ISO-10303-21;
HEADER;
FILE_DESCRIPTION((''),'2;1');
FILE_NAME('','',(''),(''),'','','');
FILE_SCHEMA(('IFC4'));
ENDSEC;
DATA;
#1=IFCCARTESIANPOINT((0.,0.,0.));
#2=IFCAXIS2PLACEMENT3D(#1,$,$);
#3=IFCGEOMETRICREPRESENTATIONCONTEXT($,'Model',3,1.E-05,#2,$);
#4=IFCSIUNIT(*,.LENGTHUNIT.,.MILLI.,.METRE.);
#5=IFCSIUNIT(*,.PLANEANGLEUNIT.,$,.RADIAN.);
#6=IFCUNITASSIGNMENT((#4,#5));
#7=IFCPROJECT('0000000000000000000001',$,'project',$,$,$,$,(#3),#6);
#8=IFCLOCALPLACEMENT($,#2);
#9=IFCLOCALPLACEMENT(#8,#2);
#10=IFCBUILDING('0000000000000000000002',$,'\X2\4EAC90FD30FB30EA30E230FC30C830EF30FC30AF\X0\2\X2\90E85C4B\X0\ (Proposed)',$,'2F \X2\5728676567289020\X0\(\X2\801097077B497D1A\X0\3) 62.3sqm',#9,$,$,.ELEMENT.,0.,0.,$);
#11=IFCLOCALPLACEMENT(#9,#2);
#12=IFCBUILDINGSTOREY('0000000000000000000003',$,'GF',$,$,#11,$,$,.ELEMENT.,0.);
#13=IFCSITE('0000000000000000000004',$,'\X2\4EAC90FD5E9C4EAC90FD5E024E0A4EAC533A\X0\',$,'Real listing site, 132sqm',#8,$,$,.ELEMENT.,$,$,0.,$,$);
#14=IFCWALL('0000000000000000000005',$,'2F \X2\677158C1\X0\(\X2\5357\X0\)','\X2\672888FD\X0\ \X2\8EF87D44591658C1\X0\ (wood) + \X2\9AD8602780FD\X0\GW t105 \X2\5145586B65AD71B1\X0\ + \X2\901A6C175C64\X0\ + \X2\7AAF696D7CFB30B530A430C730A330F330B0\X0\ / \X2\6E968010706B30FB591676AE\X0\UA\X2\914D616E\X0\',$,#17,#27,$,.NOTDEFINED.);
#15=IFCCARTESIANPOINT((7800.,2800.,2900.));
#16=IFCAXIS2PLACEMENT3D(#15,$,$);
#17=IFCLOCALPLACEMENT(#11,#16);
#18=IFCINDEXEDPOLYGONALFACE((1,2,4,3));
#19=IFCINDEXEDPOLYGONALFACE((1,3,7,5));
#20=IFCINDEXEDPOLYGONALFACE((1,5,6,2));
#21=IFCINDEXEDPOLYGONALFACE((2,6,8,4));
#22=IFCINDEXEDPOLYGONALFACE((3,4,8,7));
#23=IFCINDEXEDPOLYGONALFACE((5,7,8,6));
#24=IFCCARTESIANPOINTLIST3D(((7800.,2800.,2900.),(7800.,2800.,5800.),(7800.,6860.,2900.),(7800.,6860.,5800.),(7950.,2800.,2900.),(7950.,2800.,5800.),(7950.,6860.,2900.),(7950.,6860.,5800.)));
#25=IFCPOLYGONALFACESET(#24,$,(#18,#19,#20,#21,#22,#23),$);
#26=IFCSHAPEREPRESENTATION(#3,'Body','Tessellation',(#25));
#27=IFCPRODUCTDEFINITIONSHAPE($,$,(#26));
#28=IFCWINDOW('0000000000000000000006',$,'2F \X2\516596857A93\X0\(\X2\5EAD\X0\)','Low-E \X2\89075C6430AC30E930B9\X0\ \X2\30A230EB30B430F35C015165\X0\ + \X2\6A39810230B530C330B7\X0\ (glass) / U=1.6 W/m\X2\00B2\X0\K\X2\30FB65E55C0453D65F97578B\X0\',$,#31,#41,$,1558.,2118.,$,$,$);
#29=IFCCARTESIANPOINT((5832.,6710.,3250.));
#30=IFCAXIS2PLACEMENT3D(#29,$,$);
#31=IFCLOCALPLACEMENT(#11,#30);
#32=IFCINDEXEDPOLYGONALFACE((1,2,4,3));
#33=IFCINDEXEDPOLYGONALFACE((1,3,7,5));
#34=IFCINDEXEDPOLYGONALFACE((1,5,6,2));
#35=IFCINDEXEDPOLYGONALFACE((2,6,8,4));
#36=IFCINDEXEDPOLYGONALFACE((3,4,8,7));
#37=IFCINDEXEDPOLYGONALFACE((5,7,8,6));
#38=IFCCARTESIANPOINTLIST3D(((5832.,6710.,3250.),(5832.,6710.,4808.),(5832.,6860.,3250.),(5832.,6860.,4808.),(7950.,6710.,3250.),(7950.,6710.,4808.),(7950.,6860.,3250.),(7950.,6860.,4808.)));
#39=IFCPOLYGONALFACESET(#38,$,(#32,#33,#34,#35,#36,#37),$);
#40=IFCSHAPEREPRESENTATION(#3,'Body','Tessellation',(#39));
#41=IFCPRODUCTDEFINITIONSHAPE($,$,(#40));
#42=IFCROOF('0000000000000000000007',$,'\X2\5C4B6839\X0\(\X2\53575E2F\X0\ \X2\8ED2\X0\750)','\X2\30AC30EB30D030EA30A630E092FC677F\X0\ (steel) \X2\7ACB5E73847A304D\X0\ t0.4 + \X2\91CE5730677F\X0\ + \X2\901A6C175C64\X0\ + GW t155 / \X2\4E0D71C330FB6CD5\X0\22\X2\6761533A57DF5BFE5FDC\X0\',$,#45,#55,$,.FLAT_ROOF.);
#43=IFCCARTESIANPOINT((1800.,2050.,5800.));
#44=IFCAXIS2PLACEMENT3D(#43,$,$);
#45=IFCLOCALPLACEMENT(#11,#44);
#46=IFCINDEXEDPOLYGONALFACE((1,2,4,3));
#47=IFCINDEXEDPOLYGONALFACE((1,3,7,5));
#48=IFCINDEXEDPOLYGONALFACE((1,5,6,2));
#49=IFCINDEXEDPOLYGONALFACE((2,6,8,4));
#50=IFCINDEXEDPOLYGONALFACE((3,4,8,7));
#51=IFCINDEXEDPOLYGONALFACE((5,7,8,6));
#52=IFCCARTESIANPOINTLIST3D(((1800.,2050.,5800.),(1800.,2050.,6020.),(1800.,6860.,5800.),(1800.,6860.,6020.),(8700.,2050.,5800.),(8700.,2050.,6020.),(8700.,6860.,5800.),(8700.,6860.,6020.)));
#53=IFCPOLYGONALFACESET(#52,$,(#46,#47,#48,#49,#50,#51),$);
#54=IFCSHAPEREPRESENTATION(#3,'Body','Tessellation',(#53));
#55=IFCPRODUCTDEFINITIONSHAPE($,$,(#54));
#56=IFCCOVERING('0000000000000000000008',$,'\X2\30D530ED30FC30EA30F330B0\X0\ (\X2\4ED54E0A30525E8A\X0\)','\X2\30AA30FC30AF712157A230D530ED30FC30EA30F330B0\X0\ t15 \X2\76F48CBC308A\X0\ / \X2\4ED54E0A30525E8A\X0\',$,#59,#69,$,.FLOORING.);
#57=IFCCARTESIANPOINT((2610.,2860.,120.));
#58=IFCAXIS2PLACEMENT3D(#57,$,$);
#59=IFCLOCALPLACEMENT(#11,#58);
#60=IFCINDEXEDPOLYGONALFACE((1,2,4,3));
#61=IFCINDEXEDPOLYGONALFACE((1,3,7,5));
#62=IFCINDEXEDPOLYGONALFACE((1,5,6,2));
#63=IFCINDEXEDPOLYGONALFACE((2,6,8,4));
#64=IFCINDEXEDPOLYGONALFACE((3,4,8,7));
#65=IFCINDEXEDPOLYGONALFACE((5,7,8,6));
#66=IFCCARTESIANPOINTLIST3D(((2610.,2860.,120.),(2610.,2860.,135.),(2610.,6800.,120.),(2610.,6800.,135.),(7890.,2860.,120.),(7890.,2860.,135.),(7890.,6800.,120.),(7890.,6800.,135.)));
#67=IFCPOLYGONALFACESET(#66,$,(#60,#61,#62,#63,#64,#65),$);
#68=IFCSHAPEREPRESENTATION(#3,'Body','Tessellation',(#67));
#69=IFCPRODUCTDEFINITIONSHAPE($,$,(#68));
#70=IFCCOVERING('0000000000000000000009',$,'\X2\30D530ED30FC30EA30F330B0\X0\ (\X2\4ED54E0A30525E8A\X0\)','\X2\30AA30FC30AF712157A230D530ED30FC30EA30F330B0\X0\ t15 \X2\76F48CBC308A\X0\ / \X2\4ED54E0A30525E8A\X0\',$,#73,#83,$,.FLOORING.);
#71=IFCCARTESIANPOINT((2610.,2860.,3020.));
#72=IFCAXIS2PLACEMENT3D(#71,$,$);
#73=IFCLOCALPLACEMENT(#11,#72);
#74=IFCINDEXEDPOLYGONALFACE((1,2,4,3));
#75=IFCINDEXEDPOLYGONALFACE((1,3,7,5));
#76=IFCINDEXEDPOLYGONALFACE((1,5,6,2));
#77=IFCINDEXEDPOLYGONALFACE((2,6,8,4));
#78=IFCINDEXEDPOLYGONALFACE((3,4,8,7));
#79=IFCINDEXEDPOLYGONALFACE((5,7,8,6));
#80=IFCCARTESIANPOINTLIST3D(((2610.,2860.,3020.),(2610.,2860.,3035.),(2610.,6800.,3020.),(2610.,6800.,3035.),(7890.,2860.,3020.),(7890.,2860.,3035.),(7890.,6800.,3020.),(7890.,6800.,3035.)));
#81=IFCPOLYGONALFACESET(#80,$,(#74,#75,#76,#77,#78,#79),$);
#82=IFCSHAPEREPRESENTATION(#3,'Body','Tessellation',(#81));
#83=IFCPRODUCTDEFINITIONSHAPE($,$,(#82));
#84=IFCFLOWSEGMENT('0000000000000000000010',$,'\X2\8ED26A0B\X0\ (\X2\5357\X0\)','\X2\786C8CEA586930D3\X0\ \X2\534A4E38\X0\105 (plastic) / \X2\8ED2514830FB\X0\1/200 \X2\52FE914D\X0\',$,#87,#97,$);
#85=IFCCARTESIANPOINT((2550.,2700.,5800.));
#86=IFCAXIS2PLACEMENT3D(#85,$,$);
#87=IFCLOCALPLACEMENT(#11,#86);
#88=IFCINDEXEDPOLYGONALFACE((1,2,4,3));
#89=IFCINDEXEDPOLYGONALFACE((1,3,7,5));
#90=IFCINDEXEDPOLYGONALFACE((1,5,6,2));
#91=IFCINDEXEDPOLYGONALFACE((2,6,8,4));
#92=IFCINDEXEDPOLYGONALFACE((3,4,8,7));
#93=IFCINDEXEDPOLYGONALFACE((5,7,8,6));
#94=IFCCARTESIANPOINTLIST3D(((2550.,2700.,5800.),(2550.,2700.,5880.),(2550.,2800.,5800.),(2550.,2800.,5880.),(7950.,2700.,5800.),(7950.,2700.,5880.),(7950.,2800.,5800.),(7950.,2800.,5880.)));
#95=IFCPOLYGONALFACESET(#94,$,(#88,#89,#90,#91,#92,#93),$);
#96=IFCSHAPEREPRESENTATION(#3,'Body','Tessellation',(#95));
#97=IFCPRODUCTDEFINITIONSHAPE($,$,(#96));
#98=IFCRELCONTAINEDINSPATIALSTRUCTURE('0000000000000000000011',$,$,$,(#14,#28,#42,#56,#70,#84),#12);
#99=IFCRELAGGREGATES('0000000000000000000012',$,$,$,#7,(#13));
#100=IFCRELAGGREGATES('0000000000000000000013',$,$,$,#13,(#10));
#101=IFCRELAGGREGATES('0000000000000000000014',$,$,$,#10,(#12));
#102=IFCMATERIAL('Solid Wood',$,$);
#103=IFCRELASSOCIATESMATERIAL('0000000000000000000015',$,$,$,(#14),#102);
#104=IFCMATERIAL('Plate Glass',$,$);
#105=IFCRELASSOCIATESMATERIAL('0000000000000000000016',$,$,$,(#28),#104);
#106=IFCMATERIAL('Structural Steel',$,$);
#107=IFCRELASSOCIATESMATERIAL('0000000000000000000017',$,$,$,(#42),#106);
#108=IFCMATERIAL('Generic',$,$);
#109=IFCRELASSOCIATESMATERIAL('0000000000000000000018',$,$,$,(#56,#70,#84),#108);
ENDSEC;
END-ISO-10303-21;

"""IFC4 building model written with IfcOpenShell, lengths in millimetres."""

from ifc_helpers import new_model, si_unit, frame, frame_2d, origin, place, context, project, spatial, rectangle, extrude, material, element, fill, save


model = new_model("IFC4")

# Units and contexts
model_context = context("Model", 3, precision=1e-05, world=origin())
ifc_project = project(units=[si_unit("LENGTHUNIT", "METRE", prefix="MILLI"), si_unit("PLANEANGLEUNIT", "RADIAN")], contexts=[model_context])

# Site, building, storey
site_placement = place(None, origin())
site = spatial("IfcSite", under=ifc_project, at=site_placement, Name="京都府京都市上京区", ObjectType="Real listing site, 132sqm", CompositionType="ELEMENT", RefElevation=0.0)
building_placement = place(site_placement, origin())
building = spatial("IfcBuilding", under=site, at=building_placement, Name="京都・リモートワーク2部屋 (Proposed)", ObjectType="2F 在来木造(耐震等級3) 62.3sqm", CompositionType="ELEMENT", ElevationOfRefHeight=0.0, ElevationOfTerrain=0.0)
storey_placement = place(building_placement, origin())
storey = spatial("IfcBuildingStorey", under=building, at=storey_placement, Name="GF", CompositionType="ELEMENT", Elevation=0.0)

# Shared definitions
ifc_material_1 = material(Name="Solid Wood")

# Wall, opening, window
ifc_material_2 = material(Name="Plate Glass")
wall_1_placement = place(storey_placement, frame((7800.0, 2800.0, 2900.0)))
wall_1 = element("IfcWall", 1, at=wall_1_placement, inside=storey, material=ifc_material_1, Name="2F 東壁(南)", Description="木製 軸組外壁 (wood) + 高性能GW t105 充填断熱 + 通気層 + 窯業系サイディング / 準耐火・外皮UA配慮", PredefinedType="NOTDEFINED", context=model_context, shape_type="SweptSolid", body=[
    extrude(rectangle(XDim=150.0, YDim=4060.0, at=frame_2d((75.0, 2030.0))), frame((7800.0, 2800.0, 2900.0)), (0.0, 0.0, 1.0), 2900.0),
])
opening_1_placement = place(storey_placement, frame((5832.0, 6710.0, 3250.0)))
opening_1 = element("IfcOpeningElement", 2, at=opening_1_placement, cuts=wall_1, PredefinedType="NOTDEFINED", context=model_context, shape_type="SweptSolid", body=[
    extrude(rectangle(XDim=2118.0, YDim=150.0, at=frame_2d((1059.0, 75.0))), frame((5832.0, 6710.0, 3250.0)), (0.0, 0.0, 1.0), 1558.0),
])
window_1_placement = place(storey_placement, frame((5832.0, 6710.0, 3250.0)))
window_1 = element("IfcWindow", 3, at=window_1_placement, inside=storey, material=ifc_material_2, Name="2F 入隅窓(庭)", Description="Low-E 複層ガラス アルゴン封入 + 樹脂サッシ (glass) / U=1.6 W/m²K・日射取得型", OverallHeight=1558.0, OverallWidth=2118.0, context=model_context, shape_type="SweptSolid", body=[
    extrude(rectangle(XDim=2118.0, YDim=150.0, at=frame_2d((1059.0, 75.0))), frame((5832.0, 6710.0, 3250.0)), (0.0, 0.0, 1.0), 1558.0),
])
fill(opening_1, window_1)

# Roof
ifc_material_3 = material(Name="Structural Steel")
for number, where, name in (
    (4, (1800.0, 2050.0, 5800.0), "屋根(南帯 軒750)"),
):
    element("IfcRoof", number, at=place(storey_placement, frame(where)), inside=storey, material=ifc_material_3, Name=name, Description="ガルバリウム鋼板 (steel) 立平葺き t0.4 + 野地板 + 通気層 + GW t155 / 不燃・法22条区域対応", PredefinedType="FLAT_ROOF", context=model_context, shape_type="SweptSolid", body=[
        extrude(rectangle(XDim=6900.0, YDim=4810.0, at=frame_2d((3450.0, 2405.0))), frame((1800.0, 2050.0, 5800.0)), (0.0, 0.0, 1.0), 220.0),
    ])

# Coverings
ifc_material_4 = material(Name="Generic")
covering_1_placement = place(storey_placement, frame((2610.0, 2860.0, 120.0)))
element("IfcCovering", 5, at=covering_1_placement, inside=storey, material=ifc_material_4, Name="フローリング (仕上げ床)", Description="オーク無垢フローリング t15 直貼り / 仕上げ床", PredefinedType="FLOORING", context=model_context, shape_type="SweptSolid", body=[
    extrude(rectangle(XDim=5280.0, YDim=3940.0, at=frame_2d((2640.0, 1970.0))), frame((2610.0, 2860.0, 120.0)), (0.0, 0.0, 1.0), 15.0),
])
covering_2_placement = place(storey_placement, frame((2610.0, 2860.0, 3020.0)))
element("IfcCovering", 6, at=covering_2_placement, inside=storey, material=ifc_material_4, Name="フローリング (仕上げ床)", Description="オーク無垢フローリング t15 直貼り / 仕上げ床", PredefinedType="FLOORING", context=model_context, shape_type="SweptSolid", body=[
    extrude(rectangle(XDim=5280.0, YDim=3940.0, at=frame_2d((2640.0, 1970.0))), frame((2610.0, 2860.0, 3020.0)), (0.0, 0.0, 1.0), 15.0),
])

# Flow segment
flow_segment_placement = place(storey_placement, frame((2550.0, 2700.0, 5800.0)))
element("IfcFlowSegment", 7, at=flow_segment_placement, inside=storey, material=ifc_material_4, Name="軒樋 (南)", Description="硬質塩ビ 半丸105 (plastic) / 軒先・1/200 勾配", context=model_context, shape_type="SweptSolid", body=[
    extrude(rectangle(XDim=5400.0, YDim=100.0, at=frame_2d((2700.0, 50.0))), frame((2550.0, 2700.0, 5800.0)), (0.0, 0.0, 1.0), 80.0),
])

save(model, "model.ifc")
